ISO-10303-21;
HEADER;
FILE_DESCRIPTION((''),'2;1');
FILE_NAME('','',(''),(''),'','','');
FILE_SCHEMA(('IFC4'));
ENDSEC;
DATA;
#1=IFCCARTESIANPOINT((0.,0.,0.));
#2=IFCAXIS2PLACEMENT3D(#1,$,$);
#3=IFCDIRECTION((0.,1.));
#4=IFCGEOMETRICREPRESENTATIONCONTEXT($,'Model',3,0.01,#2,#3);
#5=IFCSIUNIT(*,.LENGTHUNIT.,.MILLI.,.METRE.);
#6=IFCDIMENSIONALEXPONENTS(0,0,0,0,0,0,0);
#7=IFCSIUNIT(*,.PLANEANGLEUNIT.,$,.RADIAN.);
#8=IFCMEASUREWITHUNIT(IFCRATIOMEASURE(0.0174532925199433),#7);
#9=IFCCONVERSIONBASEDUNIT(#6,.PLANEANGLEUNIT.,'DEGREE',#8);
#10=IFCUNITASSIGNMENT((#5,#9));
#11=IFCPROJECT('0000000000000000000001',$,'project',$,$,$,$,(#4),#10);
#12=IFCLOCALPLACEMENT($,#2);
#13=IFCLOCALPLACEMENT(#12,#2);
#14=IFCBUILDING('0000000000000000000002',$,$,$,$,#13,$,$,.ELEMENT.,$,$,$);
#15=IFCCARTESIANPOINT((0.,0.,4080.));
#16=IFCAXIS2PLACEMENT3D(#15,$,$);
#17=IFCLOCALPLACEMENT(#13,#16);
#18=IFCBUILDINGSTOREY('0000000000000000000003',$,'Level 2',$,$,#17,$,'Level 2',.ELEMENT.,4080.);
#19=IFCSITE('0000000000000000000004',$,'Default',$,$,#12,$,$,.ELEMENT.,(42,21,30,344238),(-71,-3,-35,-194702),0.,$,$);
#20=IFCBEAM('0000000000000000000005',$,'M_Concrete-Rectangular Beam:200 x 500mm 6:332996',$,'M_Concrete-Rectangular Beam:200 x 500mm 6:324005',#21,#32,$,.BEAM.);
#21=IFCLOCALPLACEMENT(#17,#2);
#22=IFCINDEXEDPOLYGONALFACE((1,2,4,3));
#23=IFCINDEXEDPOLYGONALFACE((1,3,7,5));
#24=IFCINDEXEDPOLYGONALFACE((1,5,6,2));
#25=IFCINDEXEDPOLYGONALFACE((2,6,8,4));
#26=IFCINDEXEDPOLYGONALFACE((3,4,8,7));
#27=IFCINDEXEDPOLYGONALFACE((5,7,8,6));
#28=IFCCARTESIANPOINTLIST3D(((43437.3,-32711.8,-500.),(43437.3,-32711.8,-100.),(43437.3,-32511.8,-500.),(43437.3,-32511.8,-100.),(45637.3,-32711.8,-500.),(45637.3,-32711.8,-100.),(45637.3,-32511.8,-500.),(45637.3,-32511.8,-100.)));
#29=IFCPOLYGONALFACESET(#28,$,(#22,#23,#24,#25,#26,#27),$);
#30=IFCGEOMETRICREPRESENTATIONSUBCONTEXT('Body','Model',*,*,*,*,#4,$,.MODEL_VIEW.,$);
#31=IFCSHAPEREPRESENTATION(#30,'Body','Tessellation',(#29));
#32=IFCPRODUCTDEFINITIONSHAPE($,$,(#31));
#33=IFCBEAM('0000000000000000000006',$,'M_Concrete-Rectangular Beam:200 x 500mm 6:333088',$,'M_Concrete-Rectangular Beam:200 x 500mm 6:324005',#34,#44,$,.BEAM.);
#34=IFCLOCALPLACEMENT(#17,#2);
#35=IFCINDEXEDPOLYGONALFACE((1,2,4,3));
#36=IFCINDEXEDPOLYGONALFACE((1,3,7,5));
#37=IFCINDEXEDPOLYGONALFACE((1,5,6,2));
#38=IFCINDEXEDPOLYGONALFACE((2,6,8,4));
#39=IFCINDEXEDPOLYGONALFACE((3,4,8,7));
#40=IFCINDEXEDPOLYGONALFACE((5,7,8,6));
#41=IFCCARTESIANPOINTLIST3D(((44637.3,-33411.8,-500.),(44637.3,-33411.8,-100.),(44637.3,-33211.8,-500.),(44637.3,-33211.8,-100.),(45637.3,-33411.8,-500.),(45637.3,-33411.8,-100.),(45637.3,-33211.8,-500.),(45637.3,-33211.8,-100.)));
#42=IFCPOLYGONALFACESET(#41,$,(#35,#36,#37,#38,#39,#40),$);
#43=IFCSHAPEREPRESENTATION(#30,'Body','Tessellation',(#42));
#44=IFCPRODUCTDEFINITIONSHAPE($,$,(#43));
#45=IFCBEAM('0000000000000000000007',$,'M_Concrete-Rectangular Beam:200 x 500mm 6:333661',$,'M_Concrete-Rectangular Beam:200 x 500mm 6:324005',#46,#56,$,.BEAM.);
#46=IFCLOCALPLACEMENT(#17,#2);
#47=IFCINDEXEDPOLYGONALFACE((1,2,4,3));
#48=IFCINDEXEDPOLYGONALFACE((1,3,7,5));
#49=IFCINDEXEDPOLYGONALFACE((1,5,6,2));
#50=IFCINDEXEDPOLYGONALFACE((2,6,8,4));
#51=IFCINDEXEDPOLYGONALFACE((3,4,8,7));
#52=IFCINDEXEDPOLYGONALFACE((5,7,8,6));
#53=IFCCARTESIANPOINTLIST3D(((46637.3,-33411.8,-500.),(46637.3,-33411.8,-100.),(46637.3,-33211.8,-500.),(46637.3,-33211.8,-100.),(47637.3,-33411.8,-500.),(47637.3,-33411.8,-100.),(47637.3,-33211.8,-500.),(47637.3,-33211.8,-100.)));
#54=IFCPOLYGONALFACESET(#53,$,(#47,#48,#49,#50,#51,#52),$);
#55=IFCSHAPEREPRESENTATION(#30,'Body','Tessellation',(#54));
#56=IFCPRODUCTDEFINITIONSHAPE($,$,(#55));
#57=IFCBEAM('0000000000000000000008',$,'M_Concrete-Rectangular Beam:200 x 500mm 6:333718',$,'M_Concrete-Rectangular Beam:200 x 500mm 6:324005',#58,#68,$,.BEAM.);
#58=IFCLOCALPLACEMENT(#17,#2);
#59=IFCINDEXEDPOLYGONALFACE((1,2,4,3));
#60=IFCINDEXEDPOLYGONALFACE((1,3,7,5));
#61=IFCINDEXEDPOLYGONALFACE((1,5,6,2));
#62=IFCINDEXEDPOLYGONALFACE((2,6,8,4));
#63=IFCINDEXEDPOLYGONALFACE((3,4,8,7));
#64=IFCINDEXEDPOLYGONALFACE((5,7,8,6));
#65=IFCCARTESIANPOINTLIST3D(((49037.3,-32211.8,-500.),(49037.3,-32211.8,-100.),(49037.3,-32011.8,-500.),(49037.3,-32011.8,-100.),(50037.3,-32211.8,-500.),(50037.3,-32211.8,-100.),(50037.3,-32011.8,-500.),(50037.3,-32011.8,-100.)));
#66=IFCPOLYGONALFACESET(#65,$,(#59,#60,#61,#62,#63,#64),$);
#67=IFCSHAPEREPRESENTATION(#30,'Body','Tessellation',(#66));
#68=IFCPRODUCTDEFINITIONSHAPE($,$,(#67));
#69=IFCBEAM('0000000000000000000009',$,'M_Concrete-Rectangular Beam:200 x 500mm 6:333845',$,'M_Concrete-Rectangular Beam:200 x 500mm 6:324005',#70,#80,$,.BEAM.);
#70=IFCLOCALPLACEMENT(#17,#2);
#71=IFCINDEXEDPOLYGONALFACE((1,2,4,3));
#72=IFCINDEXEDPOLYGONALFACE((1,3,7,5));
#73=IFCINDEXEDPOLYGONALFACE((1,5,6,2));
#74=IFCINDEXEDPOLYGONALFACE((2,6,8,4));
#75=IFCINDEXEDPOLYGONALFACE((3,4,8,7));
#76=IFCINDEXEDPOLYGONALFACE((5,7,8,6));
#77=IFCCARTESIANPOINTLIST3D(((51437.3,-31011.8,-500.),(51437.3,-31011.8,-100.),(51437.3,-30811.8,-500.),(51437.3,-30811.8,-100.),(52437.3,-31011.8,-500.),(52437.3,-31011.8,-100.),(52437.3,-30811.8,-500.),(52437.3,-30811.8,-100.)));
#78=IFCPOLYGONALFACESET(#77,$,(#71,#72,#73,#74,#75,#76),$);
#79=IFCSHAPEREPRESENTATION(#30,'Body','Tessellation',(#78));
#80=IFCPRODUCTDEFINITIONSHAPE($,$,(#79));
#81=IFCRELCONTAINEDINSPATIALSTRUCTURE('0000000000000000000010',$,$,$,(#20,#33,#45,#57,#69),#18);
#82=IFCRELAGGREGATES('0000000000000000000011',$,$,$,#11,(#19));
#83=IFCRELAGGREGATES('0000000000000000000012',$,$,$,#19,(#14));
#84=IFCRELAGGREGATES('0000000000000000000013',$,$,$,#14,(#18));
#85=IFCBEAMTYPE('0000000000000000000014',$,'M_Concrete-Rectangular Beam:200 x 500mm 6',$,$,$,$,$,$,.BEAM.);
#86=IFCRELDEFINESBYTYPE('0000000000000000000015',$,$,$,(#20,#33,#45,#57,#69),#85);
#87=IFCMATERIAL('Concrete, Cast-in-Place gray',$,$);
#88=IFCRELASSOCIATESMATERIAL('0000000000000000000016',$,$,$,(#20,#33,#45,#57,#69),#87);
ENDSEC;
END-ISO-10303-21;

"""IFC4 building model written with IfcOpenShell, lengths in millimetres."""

from ifc_helpers import new_model, entity, si_unit, converted_unit, direction, frame, frame_2d, origin, place, context, subcontext, project, spatial, rectangle, extrude, material, type_object, element, save


model = new_model("IFC4")

# Units and contexts
model_context = context("Model", 3, precision=0.01, world=origin(), true_north=direction((0.0, 1.0)))
body_context = subcontext(model_context, "Body", "Model", "MODEL_VIEW")
ifc_project = project(units=[si_unit("LENGTHUNIT", "METRE", prefix="MILLI"), converted_unit("PLANEANGLEUNIT", "DEGREE", entity("IfcRatioMeasure", 0.0174532925199433), si_unit("PLANEANGLEUNIT", "RADIAN"), dimensions=[0, 0, 0, 0, 0, 0, 0])], contexts=[model_context])

# Site, building, storey
site_placement = place(None, origin())
site = spatial("IfcSite", under=ifc_project, at=site_placement, Name="Default", CompositionType="ELEMENT", RefLatitude=(42, 21, 30, 344238), RefLongitude=(-71, -3, -35, -194702), RefElevation=0.0)
building_placement = place(site_placement, origin())
building = spatial("IfcBuilding", under=site, at=building_placement, CompositionType="ELEMENT")
storey_placement = place(building_placement, frame((0.0, 0.0, 4080.0)))
storey = spatial("IfcBuildingStorey", under=building, at=storey_placement, Name="Level 2", LongName="Level 2", CompositionType="ELEMENT", Elevation=4080.0)

# Beams
ifc_material_1 = material(Name="Concrete, Cast-in-Place gray")
beam_type_1 = type_object("IfcBeamType", Name="M_Concrete-Rectangular Beam:200 x 500mm 6", PredefinedType="BEAM")
beam_1_placement = place(storey_placement, frame((43337.3, -32611.8, 0.0)))
element("IfcBeam", 1, at=beam_1_placement, inside=storey, type_object=beam_type_1, material=ifc_material_1, Name="M_Concrete-Rectangular Beam:200 x 500mm 6:332996", ObjectType="M_Concrete-Rectangular Beam:200 x 500mm 6:324005", PredefinedType="BEAM", context=body_context, shape_type="SweptSolid", body=[
    extrude(rectangle(XDim=400.0, YDim=200.0, at=frame_2d((0.0, 0.0), x_axis=(1.0, 0.0))), frame((100.0, 0.0, -300.0), z_axis=(1.0, 0.0, 0.0), x_axis=(0.0, 0.0, -1.0)), (0.0, 0.0, 1.0), 2200.0),
])
beam_2_placement = place(storey_placement, frame((46137.3, -33311.8, 0.0), z_axis=(0.0, 0.0, 1.0), x_axis=(-1.0, 0.0, 0.0)))
element("IfcBeam", 2, at=beam_2_placement, inside=storey, type_object=beam_type_1, material=ifc_material_1, Name="M_Concrete-Rectangular Beam:200 x 500mm 6:333088", ObjectType="M_Concrete-Rectangular Beam:200 x 500mm 6:324005", PredefinedType="BEAM", context=body_context, shape_type="SweptSolid", body=[
    extrude(rectangle(XDim=400.0, YDim=200.0, at=frame_2d((0.0, 0.0), x_axis=(1.0, 0.0))), frame((500.0, 0.0, -300.0), z_axis=(1.0, 0.0, 0.0), x_axis=(0.0, 0.0, -1.0)), (0.0, 0.0, 1.0), 1000.0),
])
beam_3_placement = place(storey_placement, frame((46137.3, -33311.8, 0.0)))
element("IfcBeam", 3, at=beam_3_placement, inside=storey, type_object=beam_type_1, material=ifc_material_1, Name="M_Concrete-Rectangular Beam:200 x 500mm 6:333661", ObjectType="M_Concrete-Rectangular Beam:200 x 500mm 6:324005", PredefinedType="BEAM", context=body_context, shape_type="SweptSolid", body=[
    extrude(rectangle(XDim=400.0, YDim=200.0, at=frame_2d((0.0, 0.0), x_axis=(1.0, 0.0))), frame((500.0, 0.0, -300.0), z_axis=(1.0, 0.0, 0.0), x_axis=(0.0, 0.0, -1.0)), (0.0, 0.0, 1.0), 1000.0),
])
beam_4_placement = place(storey_placement, frame((48937.3, -32111.8, 0.0)))
element("IfcBeam", 4, at=beam_4_placement, inside=storey, type_object=beam_type_1, material=ifc_material_1, Name="M_Concrete-Rectangular Beam:200 x 500mm 6:333718", ObjectType="M_Concrete-Rectangular Beam:200 x 500mm 6:324005", PredefinedType="BEAM", context=body_context, shape_type="SweptSolid", body=[
    extrude(rectangle(XDim=400.0, YDim=200.0, at=frame_2d((0.0, 0.0), x_axis=(1.0, 0.0))), frame((100.0, 0.0, -300.0), z_axis=(1.0, 0.0, 0.0), x_axis=(0.0, 0.0, -1.0)), (0.0, 0.0, 1.0), 1000.0),
])
beam_5_placement = place(storey_placement, frame((51337.3, -30911.8, 0.0)))
element("IfcBeam", 5, at=beam_5_placement, inside=storey, type_object=beam_type_1, material=ifc_material_1, Name="M_Concrete-Rectangular Beam:200 x 500mm 6:333845", ObjectType="M_Concrete-Rectangular Beam:200 x 500mm 6:324005", PredefinedType="BEAM", context=body_context, shape_type="SweptSolid", body=[
    extrude(rectangle(XDim=400.0, YDim=200.0, at=frame_2d((0.0, 0.0), x_axis=(1.0, 0.0))), frame((100.0, 0.0, -300.0), z_axis=(1.0, 0.0, 0.0), x_axis=(0.0, 0.0, -1.0)), (0.0, 0.0, 1.0), 1000.0),
])

save(model, "model.ifc")
